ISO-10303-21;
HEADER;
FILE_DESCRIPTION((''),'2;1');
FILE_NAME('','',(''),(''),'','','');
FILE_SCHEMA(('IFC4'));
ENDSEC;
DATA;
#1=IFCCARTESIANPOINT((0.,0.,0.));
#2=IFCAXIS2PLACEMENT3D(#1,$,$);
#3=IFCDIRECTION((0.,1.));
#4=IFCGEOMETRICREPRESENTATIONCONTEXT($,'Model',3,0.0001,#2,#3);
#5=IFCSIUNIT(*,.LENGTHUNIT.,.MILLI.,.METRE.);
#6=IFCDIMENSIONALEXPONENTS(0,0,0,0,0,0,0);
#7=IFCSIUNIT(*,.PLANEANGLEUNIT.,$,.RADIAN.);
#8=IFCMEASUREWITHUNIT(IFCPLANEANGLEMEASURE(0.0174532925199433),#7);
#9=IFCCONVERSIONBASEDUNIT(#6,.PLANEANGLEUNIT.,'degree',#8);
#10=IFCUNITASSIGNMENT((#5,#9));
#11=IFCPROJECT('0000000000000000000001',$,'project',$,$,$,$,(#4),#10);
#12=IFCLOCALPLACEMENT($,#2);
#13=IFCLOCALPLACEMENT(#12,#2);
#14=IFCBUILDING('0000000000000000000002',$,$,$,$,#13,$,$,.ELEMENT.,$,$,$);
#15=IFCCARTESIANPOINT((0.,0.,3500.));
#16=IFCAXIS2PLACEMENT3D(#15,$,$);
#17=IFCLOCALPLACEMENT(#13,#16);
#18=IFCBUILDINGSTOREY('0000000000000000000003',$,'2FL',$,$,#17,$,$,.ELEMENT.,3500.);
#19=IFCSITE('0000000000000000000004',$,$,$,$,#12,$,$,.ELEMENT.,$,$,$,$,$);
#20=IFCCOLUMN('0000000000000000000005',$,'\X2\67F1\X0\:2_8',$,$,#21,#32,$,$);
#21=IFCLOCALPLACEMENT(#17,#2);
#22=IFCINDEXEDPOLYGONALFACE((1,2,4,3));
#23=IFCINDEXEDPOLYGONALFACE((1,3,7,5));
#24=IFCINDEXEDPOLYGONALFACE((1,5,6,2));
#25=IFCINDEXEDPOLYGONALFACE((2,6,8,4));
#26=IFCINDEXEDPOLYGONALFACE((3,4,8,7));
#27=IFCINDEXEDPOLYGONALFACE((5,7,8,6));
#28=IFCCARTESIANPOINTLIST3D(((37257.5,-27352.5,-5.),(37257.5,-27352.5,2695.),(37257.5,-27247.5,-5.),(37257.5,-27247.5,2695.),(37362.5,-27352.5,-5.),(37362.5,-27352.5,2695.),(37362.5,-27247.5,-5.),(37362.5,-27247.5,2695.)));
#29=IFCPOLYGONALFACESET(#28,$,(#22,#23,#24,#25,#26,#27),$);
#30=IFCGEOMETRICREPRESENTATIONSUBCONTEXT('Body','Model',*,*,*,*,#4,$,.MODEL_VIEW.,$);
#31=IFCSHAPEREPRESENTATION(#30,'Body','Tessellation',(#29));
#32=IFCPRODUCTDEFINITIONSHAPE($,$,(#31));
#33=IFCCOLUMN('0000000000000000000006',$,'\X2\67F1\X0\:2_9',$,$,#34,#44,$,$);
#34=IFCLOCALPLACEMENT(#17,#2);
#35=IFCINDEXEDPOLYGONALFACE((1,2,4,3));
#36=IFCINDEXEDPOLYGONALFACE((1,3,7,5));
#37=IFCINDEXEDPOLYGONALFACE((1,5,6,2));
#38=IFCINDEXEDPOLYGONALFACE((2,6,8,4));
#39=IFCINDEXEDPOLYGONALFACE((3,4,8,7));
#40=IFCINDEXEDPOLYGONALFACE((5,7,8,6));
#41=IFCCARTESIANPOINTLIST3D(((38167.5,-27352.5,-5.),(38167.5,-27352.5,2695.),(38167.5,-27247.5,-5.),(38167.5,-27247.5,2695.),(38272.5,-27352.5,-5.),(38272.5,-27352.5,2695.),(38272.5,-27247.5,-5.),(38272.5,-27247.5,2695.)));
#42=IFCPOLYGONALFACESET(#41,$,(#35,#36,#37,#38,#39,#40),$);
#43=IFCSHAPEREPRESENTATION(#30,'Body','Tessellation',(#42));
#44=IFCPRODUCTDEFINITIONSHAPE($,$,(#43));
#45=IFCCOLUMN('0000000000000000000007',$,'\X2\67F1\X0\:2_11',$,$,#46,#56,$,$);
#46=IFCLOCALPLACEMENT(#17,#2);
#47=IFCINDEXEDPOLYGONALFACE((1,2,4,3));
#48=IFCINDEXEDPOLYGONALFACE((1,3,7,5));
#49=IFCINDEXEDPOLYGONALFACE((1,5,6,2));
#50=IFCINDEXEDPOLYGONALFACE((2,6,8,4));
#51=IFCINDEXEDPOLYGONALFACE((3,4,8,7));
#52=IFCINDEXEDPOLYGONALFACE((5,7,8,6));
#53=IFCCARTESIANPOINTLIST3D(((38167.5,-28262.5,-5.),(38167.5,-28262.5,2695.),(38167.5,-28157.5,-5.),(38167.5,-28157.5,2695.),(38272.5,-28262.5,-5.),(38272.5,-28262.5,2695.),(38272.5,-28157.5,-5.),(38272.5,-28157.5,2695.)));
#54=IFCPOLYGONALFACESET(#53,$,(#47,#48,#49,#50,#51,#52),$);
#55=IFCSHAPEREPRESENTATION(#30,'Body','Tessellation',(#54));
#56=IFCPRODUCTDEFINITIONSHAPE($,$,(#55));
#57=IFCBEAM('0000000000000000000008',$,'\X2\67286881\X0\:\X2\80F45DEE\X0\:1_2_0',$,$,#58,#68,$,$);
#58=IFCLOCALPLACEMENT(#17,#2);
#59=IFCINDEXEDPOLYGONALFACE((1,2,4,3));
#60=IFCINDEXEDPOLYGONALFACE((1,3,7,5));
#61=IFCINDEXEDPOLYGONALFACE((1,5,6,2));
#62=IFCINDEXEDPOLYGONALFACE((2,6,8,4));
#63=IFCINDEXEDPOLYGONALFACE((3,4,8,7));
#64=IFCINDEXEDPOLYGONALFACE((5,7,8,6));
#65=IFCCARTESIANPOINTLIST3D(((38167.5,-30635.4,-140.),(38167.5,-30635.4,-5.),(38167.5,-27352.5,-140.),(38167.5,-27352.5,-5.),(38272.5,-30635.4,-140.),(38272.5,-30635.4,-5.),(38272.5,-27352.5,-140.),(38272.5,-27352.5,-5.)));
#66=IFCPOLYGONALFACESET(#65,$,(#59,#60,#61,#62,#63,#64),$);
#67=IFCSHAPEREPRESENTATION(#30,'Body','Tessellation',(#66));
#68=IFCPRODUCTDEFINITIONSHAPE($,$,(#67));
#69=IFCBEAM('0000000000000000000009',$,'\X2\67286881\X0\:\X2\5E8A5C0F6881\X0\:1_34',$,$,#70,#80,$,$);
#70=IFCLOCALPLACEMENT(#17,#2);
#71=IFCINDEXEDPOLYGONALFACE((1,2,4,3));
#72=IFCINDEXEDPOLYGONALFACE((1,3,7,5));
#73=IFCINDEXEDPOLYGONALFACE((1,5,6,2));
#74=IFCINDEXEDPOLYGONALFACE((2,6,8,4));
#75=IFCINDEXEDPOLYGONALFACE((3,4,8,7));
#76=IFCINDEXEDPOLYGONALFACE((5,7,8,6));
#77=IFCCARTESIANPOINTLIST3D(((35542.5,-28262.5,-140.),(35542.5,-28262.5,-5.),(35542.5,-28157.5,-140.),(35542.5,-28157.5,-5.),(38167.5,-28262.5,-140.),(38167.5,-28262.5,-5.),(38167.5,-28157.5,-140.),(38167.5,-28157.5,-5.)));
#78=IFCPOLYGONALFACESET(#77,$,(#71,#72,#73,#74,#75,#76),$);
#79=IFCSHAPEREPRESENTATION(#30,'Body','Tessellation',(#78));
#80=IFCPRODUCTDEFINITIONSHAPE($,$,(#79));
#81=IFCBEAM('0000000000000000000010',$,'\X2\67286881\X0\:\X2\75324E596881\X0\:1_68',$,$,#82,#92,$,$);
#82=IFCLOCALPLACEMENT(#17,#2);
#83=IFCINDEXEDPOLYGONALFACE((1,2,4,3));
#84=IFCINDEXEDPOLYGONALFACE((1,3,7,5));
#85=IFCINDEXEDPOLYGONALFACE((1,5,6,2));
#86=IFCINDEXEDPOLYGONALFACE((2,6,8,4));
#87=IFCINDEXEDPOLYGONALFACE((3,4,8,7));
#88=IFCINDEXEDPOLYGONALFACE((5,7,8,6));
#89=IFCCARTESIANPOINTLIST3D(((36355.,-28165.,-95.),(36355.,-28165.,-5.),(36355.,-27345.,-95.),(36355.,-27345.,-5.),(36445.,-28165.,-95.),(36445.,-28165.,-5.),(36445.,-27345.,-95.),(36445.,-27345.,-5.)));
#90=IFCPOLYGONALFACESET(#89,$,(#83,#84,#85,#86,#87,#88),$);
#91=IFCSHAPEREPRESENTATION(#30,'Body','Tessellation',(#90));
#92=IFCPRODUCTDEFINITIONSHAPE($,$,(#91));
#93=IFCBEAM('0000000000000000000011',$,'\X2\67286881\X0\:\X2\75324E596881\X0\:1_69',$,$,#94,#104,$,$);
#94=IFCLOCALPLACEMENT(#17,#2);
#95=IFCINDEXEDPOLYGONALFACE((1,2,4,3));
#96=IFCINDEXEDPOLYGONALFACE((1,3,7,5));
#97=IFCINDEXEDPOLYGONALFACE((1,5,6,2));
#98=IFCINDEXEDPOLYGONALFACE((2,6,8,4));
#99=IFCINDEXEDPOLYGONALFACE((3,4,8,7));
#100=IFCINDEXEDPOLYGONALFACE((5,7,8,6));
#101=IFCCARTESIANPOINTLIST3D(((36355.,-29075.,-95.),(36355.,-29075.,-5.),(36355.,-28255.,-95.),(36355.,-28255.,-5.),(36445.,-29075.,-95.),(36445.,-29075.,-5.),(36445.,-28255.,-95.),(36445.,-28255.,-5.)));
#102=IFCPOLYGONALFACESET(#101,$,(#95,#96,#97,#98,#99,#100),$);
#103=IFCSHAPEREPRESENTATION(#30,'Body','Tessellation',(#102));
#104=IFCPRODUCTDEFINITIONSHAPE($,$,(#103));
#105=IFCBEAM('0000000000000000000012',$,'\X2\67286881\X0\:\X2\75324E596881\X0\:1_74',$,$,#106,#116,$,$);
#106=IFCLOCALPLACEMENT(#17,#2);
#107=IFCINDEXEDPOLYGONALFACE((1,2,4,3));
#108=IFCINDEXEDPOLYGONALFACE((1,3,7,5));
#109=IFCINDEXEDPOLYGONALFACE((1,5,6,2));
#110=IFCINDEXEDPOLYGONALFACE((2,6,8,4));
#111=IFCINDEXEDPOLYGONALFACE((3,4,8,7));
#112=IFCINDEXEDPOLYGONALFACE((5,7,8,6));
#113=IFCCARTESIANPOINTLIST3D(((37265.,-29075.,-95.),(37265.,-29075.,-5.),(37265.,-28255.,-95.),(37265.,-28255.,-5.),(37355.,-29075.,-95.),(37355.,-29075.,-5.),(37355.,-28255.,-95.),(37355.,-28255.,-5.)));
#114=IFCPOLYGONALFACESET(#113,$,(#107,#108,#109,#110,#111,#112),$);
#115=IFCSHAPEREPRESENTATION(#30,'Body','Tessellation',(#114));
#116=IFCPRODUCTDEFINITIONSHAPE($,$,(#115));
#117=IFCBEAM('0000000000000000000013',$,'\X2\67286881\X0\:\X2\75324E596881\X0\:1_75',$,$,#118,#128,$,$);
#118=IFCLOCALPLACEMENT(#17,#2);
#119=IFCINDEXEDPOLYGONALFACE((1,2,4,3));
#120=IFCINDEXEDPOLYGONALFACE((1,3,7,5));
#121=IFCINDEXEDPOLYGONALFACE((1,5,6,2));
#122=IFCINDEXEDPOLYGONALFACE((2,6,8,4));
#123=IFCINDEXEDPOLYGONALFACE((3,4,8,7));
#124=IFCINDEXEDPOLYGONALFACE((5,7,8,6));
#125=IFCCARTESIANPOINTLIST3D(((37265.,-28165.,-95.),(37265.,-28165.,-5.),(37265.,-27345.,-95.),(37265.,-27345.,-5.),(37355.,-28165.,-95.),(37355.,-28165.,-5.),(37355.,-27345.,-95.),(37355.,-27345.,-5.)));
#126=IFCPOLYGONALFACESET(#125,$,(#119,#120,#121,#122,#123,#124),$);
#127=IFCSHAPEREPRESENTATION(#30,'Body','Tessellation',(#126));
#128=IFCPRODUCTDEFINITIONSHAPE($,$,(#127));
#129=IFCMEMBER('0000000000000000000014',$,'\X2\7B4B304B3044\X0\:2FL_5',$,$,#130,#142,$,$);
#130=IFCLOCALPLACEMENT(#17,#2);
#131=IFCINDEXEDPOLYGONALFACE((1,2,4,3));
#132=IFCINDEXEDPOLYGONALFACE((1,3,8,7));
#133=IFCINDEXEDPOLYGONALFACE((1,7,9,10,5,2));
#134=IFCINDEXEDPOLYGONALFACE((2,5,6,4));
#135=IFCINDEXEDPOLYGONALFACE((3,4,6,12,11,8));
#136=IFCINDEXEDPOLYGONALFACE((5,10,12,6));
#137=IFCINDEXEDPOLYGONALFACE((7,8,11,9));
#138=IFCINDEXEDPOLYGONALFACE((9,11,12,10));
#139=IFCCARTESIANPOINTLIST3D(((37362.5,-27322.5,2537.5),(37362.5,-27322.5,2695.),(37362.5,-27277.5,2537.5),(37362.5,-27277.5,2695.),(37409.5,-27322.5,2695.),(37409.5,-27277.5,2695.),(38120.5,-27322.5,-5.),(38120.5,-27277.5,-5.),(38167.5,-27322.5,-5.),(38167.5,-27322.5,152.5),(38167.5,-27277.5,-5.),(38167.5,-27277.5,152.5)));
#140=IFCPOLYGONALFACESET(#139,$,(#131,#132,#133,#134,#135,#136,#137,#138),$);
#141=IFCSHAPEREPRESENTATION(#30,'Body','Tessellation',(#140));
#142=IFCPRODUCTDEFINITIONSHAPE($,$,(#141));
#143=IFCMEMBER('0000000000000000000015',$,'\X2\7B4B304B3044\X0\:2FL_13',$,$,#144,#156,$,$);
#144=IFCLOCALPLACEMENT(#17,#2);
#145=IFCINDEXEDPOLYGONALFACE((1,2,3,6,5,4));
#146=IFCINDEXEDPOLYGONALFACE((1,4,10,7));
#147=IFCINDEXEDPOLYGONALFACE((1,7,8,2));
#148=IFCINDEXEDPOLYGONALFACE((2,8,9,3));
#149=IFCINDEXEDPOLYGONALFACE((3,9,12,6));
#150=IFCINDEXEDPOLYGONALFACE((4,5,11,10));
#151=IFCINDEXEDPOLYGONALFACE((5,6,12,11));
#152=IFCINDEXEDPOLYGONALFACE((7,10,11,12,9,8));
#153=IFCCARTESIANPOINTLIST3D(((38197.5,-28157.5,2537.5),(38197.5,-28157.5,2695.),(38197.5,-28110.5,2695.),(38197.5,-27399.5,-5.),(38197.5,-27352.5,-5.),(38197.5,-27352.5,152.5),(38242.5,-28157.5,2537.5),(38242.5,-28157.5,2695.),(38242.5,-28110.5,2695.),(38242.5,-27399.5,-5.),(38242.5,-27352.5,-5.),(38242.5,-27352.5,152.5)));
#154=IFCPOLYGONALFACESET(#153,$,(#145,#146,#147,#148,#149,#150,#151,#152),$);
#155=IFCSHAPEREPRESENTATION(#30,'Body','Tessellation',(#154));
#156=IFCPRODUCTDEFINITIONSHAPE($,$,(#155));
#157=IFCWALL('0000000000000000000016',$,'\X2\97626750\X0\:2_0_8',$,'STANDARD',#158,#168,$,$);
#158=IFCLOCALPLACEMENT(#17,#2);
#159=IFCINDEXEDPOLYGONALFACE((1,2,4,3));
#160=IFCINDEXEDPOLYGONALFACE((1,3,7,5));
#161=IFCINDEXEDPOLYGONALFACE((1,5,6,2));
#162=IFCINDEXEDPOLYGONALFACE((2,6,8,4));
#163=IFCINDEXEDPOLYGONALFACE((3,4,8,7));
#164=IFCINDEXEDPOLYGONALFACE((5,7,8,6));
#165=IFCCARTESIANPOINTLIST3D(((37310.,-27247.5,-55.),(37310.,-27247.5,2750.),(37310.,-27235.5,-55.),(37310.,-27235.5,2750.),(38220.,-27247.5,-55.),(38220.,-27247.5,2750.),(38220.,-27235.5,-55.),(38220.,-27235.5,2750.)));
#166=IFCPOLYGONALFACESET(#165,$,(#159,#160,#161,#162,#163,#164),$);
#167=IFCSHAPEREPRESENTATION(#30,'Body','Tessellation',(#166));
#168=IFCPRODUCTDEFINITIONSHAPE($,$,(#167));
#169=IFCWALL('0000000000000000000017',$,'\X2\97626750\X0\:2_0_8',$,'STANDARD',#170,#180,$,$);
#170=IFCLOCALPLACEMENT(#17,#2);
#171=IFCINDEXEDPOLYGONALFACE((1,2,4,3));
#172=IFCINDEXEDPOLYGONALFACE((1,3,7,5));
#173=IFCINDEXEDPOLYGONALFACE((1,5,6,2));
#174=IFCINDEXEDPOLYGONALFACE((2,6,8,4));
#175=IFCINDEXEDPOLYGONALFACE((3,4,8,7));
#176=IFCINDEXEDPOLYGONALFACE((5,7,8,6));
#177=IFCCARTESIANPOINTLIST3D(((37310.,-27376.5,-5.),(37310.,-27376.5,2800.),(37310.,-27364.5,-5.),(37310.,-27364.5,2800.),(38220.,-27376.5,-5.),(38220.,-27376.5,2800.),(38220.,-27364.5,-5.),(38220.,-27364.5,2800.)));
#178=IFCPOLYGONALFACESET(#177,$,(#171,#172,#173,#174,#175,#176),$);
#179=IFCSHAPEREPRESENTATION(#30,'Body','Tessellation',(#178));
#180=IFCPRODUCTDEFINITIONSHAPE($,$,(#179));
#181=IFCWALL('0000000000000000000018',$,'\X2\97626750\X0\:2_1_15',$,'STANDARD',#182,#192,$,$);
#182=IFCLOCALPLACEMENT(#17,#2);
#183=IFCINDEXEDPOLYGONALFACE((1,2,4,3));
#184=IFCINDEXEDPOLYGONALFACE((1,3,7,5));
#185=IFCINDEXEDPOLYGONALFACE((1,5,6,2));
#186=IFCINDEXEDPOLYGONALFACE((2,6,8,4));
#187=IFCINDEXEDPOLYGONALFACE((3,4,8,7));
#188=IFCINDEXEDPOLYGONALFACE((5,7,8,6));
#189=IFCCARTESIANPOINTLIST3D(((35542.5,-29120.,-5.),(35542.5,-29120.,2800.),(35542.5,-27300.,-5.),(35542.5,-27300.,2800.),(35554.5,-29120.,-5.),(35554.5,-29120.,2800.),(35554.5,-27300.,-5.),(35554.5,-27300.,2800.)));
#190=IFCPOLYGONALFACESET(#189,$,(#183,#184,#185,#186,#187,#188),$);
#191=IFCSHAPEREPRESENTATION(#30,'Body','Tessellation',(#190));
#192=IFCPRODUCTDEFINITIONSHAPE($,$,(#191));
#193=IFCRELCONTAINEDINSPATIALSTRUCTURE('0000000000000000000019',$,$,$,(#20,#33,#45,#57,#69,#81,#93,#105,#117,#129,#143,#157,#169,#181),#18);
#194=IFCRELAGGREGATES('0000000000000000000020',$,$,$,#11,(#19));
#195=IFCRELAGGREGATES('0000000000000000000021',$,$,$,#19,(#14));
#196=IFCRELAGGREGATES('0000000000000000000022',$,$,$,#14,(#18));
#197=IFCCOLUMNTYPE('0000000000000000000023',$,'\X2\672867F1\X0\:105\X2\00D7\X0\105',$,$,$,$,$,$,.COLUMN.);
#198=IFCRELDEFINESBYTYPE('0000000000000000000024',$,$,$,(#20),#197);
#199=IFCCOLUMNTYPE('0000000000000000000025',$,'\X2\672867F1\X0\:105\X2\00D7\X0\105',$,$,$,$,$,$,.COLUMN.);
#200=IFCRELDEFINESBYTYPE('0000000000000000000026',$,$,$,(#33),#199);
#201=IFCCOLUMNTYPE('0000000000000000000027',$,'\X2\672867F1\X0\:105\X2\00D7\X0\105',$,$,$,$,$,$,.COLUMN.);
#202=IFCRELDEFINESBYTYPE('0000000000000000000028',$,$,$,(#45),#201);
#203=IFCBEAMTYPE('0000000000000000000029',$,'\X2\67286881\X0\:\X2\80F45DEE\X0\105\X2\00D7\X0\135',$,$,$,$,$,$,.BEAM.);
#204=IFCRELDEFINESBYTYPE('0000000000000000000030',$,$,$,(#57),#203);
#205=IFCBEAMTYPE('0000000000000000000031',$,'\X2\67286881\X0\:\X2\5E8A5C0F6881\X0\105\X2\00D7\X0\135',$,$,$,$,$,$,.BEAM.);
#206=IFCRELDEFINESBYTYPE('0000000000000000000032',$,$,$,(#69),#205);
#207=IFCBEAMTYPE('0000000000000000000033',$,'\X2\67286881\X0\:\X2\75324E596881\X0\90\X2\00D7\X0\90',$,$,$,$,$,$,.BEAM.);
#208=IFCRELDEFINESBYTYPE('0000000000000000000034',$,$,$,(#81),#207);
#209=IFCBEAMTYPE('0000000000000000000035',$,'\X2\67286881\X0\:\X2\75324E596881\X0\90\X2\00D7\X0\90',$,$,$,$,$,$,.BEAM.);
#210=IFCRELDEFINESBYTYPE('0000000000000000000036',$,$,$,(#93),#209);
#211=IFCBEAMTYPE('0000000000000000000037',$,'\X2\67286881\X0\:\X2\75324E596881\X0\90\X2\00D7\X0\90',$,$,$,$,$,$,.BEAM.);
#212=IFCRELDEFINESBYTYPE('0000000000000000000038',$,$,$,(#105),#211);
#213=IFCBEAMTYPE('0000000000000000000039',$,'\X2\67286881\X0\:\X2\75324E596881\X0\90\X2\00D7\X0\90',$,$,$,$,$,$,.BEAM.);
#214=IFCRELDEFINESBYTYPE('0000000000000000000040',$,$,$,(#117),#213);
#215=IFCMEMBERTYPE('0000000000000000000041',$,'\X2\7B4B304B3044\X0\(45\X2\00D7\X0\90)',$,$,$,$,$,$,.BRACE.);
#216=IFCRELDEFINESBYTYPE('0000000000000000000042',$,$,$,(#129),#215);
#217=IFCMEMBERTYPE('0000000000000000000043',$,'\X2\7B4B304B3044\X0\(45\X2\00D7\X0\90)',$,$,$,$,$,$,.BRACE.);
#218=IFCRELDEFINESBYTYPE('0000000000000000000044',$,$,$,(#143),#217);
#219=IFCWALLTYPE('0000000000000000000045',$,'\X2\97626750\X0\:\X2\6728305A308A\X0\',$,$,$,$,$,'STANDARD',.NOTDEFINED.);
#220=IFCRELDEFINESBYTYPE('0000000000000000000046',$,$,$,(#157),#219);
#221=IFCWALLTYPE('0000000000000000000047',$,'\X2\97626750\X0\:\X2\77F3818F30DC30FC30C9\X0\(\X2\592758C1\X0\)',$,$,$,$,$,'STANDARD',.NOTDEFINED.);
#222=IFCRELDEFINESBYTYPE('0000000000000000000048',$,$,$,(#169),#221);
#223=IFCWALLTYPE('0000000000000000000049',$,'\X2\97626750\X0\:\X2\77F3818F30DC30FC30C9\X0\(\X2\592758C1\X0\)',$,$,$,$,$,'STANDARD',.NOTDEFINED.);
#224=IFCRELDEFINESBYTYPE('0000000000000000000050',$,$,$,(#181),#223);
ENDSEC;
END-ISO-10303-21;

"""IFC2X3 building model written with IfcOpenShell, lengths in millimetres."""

from ifc_helpers import new_model, entity, si_unit, converted_unit, direction, frame, origin, origin_with_axes, origin_2d, place, context, subcontext, project, spatial, polyline, rectangle, outline, extrude, type_object, element, save


model = new_model("IFC2X3")

# Units and contexts
model_context = context("Model", 3, precision=0.0001, world=origin(), true_north=direction((0.0, 1.0)))
body_context = subcontext(model_context, "Body", "Model", "MODEL_VIEW")
ifc_project = project(units=[si_unit("LENGTHUNIT", "METRE", prefix="MILLI"), converted_unit("PLANEANGLEUNIT", "degree", entity("IfcPlaneAngleMeasure", 0.0174532925199433), si_unit("PLANEANGLEUNIT", "RADIAN"), dimensions=[0, 0, 0, 0, 0, 0, 0])], contexts=[model_context])

# Site, building, storey
site_placement = place(None, origin())
site = spatial("IfcSite", under=ifc_project, at=site_placement, CompositionType="ELEMENT")
building_placement = place(site_placement, origin())
building = spatial("IfcBuilding", under=site, at=building_placement, CompositionType="ELEMENT")
storey_placement = place(building_placement, frame((0.0, 0.0, 3500.0)))
storey = spatial("IfcBuildingStorey", under=building, at=storey_placement, Name="2FL", CompositionType="ELEMENT", Elevation=3500.0)

# Columns
column_type_1 = type_object("IfcColumnType", Name="木柱:105×105", PredefinedType="COLUMN")
column_1_placement = place(storey_placement, frame((37310.0, -27300.0, -5.0)))
element("IfcColumn", 1, at=column_1_placement, inside=storey, type_object=column_type_1, Name="柱:2_8", context=body_context, shape_type="SweptSolid", body=[
    extrude(rectangle(XDim=105.0, YDim=105.0, at=origin_2d()), origin_with_axes(), (0.0, 0.0, 1.0), 2700.0),
])
column_type_2 = type_object("IfcColumnType", Name="木柱:105×105", PredefinedType="COLUMN")
column_2_placement = place(storey_placement, frame((38220.0, -27300.0, -5.0)))
element("IfcColumn", 2, at=column_2_placement, inside=storey, type_object=column_type_2, Name="柱:2_9", context=body_context, shape_type="SweptSolid", body=[
    extrude(rectangle(XDim=105.0, YDim=105.0, at=origin_2d()), origin_with_axes(), (0.0, 0.0, 1.0), 2700.0),
])
column_type_3 = type_object("IfcColumnType", Name="木柱:105×105", PredefinedType="COLUMN")
column_3_placement = place(storey_placement, frame((38220.0, -28210.0, -5.0)))
element("IfcColumn", 3, at=column_3_placement, inside=storey, type_object=column_type_3, Name="柱:2_11", context=body_context, shape_type="SweptSolid", body=[
    extrude(rectangle(XDim=105.0, YDim=105.0, at=origin_2d()), origin_with_axes(), (0.0, 0.0, 1.0), 2700.0),
])

# Beams
beam_type_1 = type_object("IfcBeamType", Name="木梁:胴差105×135", PredefinedType="BEAM")
beam_1_placement = place(storey_placement, frame((38220.0, -27352.5, -72.5), z_axis=(0.0, -1.0, 0.0), x_axis=(1.0, 0.0, 0.0)))
element("IfcBeam", 4, at=beam_1_placement, inside=storey, type_object=beam_type_1, Name="木梁:胴差:1_2_0", context=body_context, shape_type="SweptSolid", body=[
    extrude(rectangle(XDim=105.0, YDim=135.0, at=origin_2d()), origin_with_axes(), (0.0, 0.0, 1.0), 3282.9),
])
beam_type_2 = type_object("IfcBeamType", Name="木梁:床小梁105×135", PredefinedType="BEAM")
beam_2_placement = place(storey_placement, frame((35542.5, -28210.0, -72.5), z_axis=(1.0, 0.0, 0.0), x_axis=(0.0, 1.0, 0.0)))
element("IfcBeam", 5, at=beam_2_placement, inside=storey, type_object=beam_type_2, Name="木梁:床小梁:1_34", context=body_context, shape_type="SweptSolid", body=[
    extrude(rectangle(XDim=105.0, YDim=135.0, at=origin_2d()), origin_with_axes(), (0.0, 0.0, 1.0), 2625.0),
])
beam_type_3 = type_object("IfcBeamType", Name="木梁:甲乙梁90×90", PredefinedType="BEAM")
beam_3_placement = place(storey_placement, frame((36400.0, -27345.0, -50.0), z_axis=(0.0, -1.0, 0.0), x_axis=(1.0, 0.0, 0.0)))
element("IfcBeam", 6, at=beam_3_placement, inside=storey, type_object=beam_type_3, Name="木梁:甲乙梁:1_68", context=body_context, shape_type="SweptSolid", body=[
    extrude(rectangle(XDim=90.0, YDim=90.0, at=origin_2d()), origin_with_axes(), (0.0, 0.0, 1.0), 820.0),
])
beam_type_4 = type_object("IfcBeamType", Name="木梁:甲乙梁90×90", PredefinedType="BEAM")
beam_4_placement = place(storey_placement, frame((36400.0, -28255.0, -50.0), z_axis=(0.0, -1.0, 0.0), x_axis=(1.0, 0.0, 0.0)))
element("IfcBeam", 7, at=beam_4_placement, inside=storey, type_object=beam_type_4, Name="木梁:甲乙梁:1_69", context=body_context, shape_type="SweptSolid", body=[
    extrude(rectangle(XDim=90.0, YDim=90.0, at=origin_2d()), origin_with_axes(), (0.0, 0.0, 1.0), 820.0),
])
beam_type_5 = type_object("IfcBeamType", Name="木梁:甲乙梁90×90", PredefinedType="BEAM")
beam_5_placement = place(storey_placement, frame((37310.0, -28255.0, -50.0), z_axis=(0.0, -1.0, 0.0), x_axis=(1.0, 0.0, 0.0)))
element("IfcBeam", 8, at=beam_5_placement, inside=storey, type_object=beam_type_5, Name="木梁:甲乙梁:1_74", context=body_context, shape_type="SweptSolid", body=[
    extrude(rectangle(XDim=90.0, YDim=90.0, at=origin_2d()), origin_with_axes(), (0.0, 0.0, 1.0), 820.0),
])
beam_type_6 = type_object("IfcBeamType", Name="木梁:甲乙梁90×90", PredefinedType="BEAM")
beam_6_placement = place(storey_placement, frame((37310.0, -27345.0, -50.0), z_axis=(0.0, -1.0, 0.0), x_axis=(1.0, 0.0, 0.0)))
element("IfcBeam", 9, at=beam_6_placement, inside=storey, type_object=beam_type_6, Name="木梁:甲乙梁:1_75", context=body_context, shape_type="SweptSolid", body=[
    extrude(rectangle(XDim=90.0, YDim=90.0, at=origin_2d()), origin_with_axes(), (0.0, 0.0, 1.0), 820.0),
])

# Members
member_type_1 = type_object("IfcMemberType", Name="筋かい(45×90)", PredefinedType="BRACE")
member_1_placement = place(storey_placement, frame((38167.5, -27300.0, -5.0), z_axis=(-0.285719, 0.0, 0.958313), x_axis=(0.958313, 0.0, 0.285719)))
element("IfcMember", 10, at=member_1_placement, inside=storey, type_object=member_type_1, Name="筋かい:2FL_5", context=body_context, shape_type="SweptSolid", body=[
    extrude(outline(polyline([(0.0, 0.0), (13.4, -45.0), (2666.5, -45.0), (2817.5, 0.0), (2804.0, 45.0), (150.9, 45.0), (0.0, 0.0)])), frame((0.0, -22.5, 0.0), z_axis=(0.0, 1.0, 0.0), x_axis=(0.0, 0.0, 1.0)), (0.0, 0.0, 1.0), 45.0),
])
member_type_2 = type_object("IfcMemberType", Name="筋かい(45×90)", PredefinedType="BRACE")
member_2_placement = place(storey_placement, frame((38220.0, -27352.5, -5.0), z_axis=(0.0, -0.285719, 0.958313), x_axis=(0.0, 0.958313, 0.285719)))
element("IfcMember", 11, at=member_2_placement, inside=storey, type_object=member_type_2, Name="筋かい:2FL_13", context=body_context, shape_type="SweptSolid", body=[
    extrude(outline(polyline([(0.0, 0.0), (13.4, -45.0), (2666.5, -45.0), (2817.5, 0.0), (2804.0, 45.0), (150.9, 45.0), (0.0, 0.0)])), frame((0.0, -22.5, 0.0), z_axis=(0.0, 1.0, 0.0), x_axis=(0.0, 0.0, 1.0)), (0.0, 0.0, 1.0), 45.0),
])

# Walls
wall_type_1 = type_object("IfcWallType", Name="面材:木ずり", ElementType="STANDARD", PredefinedType="NOTDEFINED")
wall_1_placement = place(storey_placement, frame((37765.0, -27235.5, -55.0), z_axis=(0.0, -1.0, 0.0), x_axis=(1.0, 0.0, 0.0)))
element("IfcWall", 12, at=wall_1_placement, inside=storey, type_object=wall_type_1, Name="面材:2_0_8", ObjectType="STANDARD", context=body_context, shape_type="SweptSolid", body=[
    extrude(outline(polyline([(455.0, 0.0, 0.0), (-455.0, 0.0, 0.0), (-455.0, 2805.0, 0.0), (455.0, 2805.0, 0.0), (455.0, 0.0, 0.0)])), origin_with_axes(), (0.0, 0.0, 1.0), 12.0),
])
wall_type_2 = type_object("IfcWallType", Name="面材:石膏ボード(大壁)", ElementType="STANDARD", PredefinedType="NOTDEFINED")
wall_2_placement = place(storey_placement, frame((37765.0, -27364.5, -5.0), z_axis=(0.0, -1.0, 0.0), x_axis=(1.0, 0.0, 0.0)))
element("IfcWall", 13, at=wall_2_placement, inside=storey, type_object=wall_type_2, Name="面材:2_0_8", ObjectType="STANDARD", context=body_context, shape_type="SweptSolid", body=[
    extrude(outline(polyline([(455.0, 0.0, 0.0), (-455.0, 0.0, 0.0), (-455.0, 2805.0, 0.0), (455.0, 2805.0, 0.0), (455.0, 0.0, 0.0)])), origin_with_axes(), (0.0, 0.0, 1.0), 12.0),
])
wall_type_3 = type_object("IfcWallType", Name="面材:石膏ボード(大壁)", ElementType="STANDARD", PredefinedType="NOTDEFINED")
wall_3_placement = place(storey_placement, frame((35554.5, -28210.0, -5.0), z_axis=(-1.0, 0.0, 0.0), x_axis=(0.0, -1.0, 0.0)))
element("IfcWall", 14, at=wall_3_placement, inside=storey, type_object=wall_type_3, Name="面材:2_1_15", ObjectType="STANDARD", context=body_context, shape_type="SweptSolid", body=[
    extrude(outline(polyline([(910.0, 0.0, 0.0), (-910.0, 0.0, 0.0), (-910.0, 2805.0, 0.0), (910.0, 2805.0, 0.0), (910.0, 0.0, 0.0)])), origin_with_axes(), (0.0, 0.0, 1.0), 12.0),
])

save(model, "model.ifc")
